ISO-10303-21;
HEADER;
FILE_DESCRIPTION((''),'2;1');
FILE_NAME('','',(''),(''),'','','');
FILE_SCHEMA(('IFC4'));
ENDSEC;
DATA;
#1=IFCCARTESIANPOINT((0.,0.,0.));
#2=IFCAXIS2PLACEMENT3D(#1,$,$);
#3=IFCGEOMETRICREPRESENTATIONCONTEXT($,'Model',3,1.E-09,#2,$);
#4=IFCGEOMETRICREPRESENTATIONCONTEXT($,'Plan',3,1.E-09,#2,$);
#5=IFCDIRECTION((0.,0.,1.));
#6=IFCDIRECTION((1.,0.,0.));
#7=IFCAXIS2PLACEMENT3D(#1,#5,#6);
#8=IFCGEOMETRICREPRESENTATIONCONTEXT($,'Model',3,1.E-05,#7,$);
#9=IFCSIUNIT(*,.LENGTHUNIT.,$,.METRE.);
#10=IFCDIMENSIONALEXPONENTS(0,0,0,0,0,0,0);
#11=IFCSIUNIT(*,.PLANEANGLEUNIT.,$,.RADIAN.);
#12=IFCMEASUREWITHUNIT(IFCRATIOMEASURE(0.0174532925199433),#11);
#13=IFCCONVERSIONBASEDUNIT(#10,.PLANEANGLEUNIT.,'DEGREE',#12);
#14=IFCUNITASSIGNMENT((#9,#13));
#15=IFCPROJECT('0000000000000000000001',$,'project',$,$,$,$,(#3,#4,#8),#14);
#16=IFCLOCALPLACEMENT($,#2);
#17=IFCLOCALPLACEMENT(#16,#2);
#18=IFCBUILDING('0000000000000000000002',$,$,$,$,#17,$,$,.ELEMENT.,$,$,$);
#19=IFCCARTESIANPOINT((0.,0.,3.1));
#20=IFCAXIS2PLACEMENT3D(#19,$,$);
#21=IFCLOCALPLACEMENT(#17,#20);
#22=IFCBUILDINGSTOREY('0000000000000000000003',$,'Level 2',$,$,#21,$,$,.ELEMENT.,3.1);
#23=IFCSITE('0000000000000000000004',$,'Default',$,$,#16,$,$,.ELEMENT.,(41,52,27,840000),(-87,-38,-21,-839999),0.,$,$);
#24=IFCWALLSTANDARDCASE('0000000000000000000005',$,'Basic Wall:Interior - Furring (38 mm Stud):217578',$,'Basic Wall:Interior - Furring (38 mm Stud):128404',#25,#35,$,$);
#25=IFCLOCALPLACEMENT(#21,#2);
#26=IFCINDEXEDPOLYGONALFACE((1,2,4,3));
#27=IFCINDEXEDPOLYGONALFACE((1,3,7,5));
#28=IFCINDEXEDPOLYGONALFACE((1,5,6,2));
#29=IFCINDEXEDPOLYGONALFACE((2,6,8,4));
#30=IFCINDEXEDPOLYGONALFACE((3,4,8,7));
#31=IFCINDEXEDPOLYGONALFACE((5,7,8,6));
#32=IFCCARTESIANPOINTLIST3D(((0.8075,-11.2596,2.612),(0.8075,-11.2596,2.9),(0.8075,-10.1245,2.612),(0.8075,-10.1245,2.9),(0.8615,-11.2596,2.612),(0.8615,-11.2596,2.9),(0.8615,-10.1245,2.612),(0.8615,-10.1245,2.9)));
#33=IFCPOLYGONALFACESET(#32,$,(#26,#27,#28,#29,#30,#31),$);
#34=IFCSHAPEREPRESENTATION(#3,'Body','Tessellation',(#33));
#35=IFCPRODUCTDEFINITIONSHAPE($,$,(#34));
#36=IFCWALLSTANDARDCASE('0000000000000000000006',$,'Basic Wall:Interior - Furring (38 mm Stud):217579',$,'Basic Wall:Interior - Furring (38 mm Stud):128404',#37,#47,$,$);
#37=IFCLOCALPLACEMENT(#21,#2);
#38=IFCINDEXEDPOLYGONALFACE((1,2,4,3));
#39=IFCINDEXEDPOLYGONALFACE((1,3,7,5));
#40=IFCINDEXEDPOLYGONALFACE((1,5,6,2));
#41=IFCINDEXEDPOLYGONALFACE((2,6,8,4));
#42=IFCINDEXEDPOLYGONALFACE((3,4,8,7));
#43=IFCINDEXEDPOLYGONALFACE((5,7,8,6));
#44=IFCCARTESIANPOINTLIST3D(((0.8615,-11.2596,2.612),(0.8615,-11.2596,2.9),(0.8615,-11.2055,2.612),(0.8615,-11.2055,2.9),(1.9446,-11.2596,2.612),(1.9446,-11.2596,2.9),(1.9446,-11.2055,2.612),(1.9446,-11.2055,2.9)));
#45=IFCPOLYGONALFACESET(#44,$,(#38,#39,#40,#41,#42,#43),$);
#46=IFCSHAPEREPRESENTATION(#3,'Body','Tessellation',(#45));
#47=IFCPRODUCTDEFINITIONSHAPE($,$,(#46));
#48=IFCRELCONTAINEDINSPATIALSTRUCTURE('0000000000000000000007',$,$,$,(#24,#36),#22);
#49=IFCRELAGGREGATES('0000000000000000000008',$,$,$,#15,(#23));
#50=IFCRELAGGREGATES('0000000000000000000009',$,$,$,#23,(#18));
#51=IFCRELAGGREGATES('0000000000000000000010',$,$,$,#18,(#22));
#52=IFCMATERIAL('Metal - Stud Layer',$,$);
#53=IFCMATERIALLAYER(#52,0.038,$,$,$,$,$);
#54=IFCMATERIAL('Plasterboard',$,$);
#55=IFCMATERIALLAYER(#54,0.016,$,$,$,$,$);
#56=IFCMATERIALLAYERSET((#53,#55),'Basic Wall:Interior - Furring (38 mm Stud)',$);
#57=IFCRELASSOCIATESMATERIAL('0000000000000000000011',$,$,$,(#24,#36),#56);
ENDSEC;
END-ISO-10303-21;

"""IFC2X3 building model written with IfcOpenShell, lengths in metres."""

from ifc_helpers import new_model, entity, si_unit, converted_unit, frame, frame_2d, origin, origin_with_axes, place, context, project, spatial, rectangle, extrude, material, layer, layer_set, layer_usage, element, save


model = new_model("IFC2X3")

# Units and contexts
model_context_1 = context("Model", 3, precision=1e-09, world=origin())
plan_context = context("Plan", 3, precision=1e-09, world=origin())
model_context_2 = context("Model", 3, precision=1e-05, world=origin_with_axes())
ifc_project = project(units=[si_unit("LENGTHUNIT", "METRE"), converted_unit("PLANEANGLEUNIT", "DEGREE", entity("IfcRatioMeasure", 0.0174532925199433), si_unit("PLANEANGLEUNIT", "RADIAN"), dimensions=[0, 0, 0, 0, 0, 0, 0])], contexts=[model_context_1, plan_context, model_context_2])

# Site, building, storey
site_placement = place(None, origin())
site = spatial("IfcSite", under=ifc_project, at=site_placement, Name="Default", CompositionType="ELEMENT", RefLatitude=(41, 52, 27, 840000), RefLongitude=(-87, -38, -21, -839999), RefElevation=0.0)
building_placement = place(site_placement, origin())
building = spatial("IfcBuilding", under=site, at=building_placement, CompositionType="ELEMENT")
storey_placement = place(building_placement, frame((0.0, 0.0, 3.1)))
storey = spatial("IfcBuildingStorey", under=building, at=storey_placement, Name="Level 2", CompositionType="ELEMENT", Elevation=3.1)

# Shared definitions
ifc_material_1 = material(Name="Metal - Stud Layer")
ifc_material_2 = material(Name="Plasterboard")

# Walls
ifc_layer_1 = layer(ifc_material_1, 0.038)
ifc_layer_2 = layer(ifc_material_2, 0.016)
ifc_layer_set_1 = layer_set([ifc_layer_1, ifc_layer_2], Name="Basic Wall:Interior - Furring (38 mm Stud)")
ifc_layer_usage_1 = layer_usage(ifc_layer_set_1, "AXIS2", "NEGATIVE", 0.027)
wall_1_placement = place(storey_placement, frame((0.8345, -11.2596, 2.612), z_axis=(0.0, 0.0, 1.0), x_axis=(0.0, 1.0, 0.0)))
element("IfcWallStandardCase", 1, at=wall_1_placement, inside=storey, material=ifc_layer_usage_1, Name="Basic Wall:Interior - Furring (38 mm Stud):217578", ObjectType="Basic Wall:Interior - Furring (38 mm Stud):128404", context=model_context_1, shape_type="SweptSolid", body=[
    extrude(rectangle(XDim=1.1351, YDim=0.054, at=frame_2d((0.5675, 0.0), x_axis=(-1.0, 0.0))), origin(), (0.0, 0.0, 1.0), 0.288),
])
ifc_layer_usage_2 = layer_usage(ifc_layer_set_1, "AXIS2", "NEGATIVE", 0.027)
wall_2_placement = place(storey_placement, frame((1.9446, -11.2325, 2.612), z_axis=(0.0, 0.0, 1.0), x_axis=(-1.0, 0.0, 0.0)))
element("IfcWallStandardCase", 2, at=wall_2_placement, inside=storey, material=ifc_layer_usage_2, Name="Basic Wall:Interior - Furring (38 mm Stud):217579", ObjectType="Basic Wall:Interior - Furring (38 mm Stud):128404", context=model_context_1, shape_type="SweptSolid", body=[
    extrude(rectangle(XDim=1.0831, YDim=0.054, at=frame_2d((0.5415, 0.0), x_axis=(-1.0, 0.0))), origin(), (0.0, 0.0, 1.0), 0.288),
])

save(model, "model.ifc")
